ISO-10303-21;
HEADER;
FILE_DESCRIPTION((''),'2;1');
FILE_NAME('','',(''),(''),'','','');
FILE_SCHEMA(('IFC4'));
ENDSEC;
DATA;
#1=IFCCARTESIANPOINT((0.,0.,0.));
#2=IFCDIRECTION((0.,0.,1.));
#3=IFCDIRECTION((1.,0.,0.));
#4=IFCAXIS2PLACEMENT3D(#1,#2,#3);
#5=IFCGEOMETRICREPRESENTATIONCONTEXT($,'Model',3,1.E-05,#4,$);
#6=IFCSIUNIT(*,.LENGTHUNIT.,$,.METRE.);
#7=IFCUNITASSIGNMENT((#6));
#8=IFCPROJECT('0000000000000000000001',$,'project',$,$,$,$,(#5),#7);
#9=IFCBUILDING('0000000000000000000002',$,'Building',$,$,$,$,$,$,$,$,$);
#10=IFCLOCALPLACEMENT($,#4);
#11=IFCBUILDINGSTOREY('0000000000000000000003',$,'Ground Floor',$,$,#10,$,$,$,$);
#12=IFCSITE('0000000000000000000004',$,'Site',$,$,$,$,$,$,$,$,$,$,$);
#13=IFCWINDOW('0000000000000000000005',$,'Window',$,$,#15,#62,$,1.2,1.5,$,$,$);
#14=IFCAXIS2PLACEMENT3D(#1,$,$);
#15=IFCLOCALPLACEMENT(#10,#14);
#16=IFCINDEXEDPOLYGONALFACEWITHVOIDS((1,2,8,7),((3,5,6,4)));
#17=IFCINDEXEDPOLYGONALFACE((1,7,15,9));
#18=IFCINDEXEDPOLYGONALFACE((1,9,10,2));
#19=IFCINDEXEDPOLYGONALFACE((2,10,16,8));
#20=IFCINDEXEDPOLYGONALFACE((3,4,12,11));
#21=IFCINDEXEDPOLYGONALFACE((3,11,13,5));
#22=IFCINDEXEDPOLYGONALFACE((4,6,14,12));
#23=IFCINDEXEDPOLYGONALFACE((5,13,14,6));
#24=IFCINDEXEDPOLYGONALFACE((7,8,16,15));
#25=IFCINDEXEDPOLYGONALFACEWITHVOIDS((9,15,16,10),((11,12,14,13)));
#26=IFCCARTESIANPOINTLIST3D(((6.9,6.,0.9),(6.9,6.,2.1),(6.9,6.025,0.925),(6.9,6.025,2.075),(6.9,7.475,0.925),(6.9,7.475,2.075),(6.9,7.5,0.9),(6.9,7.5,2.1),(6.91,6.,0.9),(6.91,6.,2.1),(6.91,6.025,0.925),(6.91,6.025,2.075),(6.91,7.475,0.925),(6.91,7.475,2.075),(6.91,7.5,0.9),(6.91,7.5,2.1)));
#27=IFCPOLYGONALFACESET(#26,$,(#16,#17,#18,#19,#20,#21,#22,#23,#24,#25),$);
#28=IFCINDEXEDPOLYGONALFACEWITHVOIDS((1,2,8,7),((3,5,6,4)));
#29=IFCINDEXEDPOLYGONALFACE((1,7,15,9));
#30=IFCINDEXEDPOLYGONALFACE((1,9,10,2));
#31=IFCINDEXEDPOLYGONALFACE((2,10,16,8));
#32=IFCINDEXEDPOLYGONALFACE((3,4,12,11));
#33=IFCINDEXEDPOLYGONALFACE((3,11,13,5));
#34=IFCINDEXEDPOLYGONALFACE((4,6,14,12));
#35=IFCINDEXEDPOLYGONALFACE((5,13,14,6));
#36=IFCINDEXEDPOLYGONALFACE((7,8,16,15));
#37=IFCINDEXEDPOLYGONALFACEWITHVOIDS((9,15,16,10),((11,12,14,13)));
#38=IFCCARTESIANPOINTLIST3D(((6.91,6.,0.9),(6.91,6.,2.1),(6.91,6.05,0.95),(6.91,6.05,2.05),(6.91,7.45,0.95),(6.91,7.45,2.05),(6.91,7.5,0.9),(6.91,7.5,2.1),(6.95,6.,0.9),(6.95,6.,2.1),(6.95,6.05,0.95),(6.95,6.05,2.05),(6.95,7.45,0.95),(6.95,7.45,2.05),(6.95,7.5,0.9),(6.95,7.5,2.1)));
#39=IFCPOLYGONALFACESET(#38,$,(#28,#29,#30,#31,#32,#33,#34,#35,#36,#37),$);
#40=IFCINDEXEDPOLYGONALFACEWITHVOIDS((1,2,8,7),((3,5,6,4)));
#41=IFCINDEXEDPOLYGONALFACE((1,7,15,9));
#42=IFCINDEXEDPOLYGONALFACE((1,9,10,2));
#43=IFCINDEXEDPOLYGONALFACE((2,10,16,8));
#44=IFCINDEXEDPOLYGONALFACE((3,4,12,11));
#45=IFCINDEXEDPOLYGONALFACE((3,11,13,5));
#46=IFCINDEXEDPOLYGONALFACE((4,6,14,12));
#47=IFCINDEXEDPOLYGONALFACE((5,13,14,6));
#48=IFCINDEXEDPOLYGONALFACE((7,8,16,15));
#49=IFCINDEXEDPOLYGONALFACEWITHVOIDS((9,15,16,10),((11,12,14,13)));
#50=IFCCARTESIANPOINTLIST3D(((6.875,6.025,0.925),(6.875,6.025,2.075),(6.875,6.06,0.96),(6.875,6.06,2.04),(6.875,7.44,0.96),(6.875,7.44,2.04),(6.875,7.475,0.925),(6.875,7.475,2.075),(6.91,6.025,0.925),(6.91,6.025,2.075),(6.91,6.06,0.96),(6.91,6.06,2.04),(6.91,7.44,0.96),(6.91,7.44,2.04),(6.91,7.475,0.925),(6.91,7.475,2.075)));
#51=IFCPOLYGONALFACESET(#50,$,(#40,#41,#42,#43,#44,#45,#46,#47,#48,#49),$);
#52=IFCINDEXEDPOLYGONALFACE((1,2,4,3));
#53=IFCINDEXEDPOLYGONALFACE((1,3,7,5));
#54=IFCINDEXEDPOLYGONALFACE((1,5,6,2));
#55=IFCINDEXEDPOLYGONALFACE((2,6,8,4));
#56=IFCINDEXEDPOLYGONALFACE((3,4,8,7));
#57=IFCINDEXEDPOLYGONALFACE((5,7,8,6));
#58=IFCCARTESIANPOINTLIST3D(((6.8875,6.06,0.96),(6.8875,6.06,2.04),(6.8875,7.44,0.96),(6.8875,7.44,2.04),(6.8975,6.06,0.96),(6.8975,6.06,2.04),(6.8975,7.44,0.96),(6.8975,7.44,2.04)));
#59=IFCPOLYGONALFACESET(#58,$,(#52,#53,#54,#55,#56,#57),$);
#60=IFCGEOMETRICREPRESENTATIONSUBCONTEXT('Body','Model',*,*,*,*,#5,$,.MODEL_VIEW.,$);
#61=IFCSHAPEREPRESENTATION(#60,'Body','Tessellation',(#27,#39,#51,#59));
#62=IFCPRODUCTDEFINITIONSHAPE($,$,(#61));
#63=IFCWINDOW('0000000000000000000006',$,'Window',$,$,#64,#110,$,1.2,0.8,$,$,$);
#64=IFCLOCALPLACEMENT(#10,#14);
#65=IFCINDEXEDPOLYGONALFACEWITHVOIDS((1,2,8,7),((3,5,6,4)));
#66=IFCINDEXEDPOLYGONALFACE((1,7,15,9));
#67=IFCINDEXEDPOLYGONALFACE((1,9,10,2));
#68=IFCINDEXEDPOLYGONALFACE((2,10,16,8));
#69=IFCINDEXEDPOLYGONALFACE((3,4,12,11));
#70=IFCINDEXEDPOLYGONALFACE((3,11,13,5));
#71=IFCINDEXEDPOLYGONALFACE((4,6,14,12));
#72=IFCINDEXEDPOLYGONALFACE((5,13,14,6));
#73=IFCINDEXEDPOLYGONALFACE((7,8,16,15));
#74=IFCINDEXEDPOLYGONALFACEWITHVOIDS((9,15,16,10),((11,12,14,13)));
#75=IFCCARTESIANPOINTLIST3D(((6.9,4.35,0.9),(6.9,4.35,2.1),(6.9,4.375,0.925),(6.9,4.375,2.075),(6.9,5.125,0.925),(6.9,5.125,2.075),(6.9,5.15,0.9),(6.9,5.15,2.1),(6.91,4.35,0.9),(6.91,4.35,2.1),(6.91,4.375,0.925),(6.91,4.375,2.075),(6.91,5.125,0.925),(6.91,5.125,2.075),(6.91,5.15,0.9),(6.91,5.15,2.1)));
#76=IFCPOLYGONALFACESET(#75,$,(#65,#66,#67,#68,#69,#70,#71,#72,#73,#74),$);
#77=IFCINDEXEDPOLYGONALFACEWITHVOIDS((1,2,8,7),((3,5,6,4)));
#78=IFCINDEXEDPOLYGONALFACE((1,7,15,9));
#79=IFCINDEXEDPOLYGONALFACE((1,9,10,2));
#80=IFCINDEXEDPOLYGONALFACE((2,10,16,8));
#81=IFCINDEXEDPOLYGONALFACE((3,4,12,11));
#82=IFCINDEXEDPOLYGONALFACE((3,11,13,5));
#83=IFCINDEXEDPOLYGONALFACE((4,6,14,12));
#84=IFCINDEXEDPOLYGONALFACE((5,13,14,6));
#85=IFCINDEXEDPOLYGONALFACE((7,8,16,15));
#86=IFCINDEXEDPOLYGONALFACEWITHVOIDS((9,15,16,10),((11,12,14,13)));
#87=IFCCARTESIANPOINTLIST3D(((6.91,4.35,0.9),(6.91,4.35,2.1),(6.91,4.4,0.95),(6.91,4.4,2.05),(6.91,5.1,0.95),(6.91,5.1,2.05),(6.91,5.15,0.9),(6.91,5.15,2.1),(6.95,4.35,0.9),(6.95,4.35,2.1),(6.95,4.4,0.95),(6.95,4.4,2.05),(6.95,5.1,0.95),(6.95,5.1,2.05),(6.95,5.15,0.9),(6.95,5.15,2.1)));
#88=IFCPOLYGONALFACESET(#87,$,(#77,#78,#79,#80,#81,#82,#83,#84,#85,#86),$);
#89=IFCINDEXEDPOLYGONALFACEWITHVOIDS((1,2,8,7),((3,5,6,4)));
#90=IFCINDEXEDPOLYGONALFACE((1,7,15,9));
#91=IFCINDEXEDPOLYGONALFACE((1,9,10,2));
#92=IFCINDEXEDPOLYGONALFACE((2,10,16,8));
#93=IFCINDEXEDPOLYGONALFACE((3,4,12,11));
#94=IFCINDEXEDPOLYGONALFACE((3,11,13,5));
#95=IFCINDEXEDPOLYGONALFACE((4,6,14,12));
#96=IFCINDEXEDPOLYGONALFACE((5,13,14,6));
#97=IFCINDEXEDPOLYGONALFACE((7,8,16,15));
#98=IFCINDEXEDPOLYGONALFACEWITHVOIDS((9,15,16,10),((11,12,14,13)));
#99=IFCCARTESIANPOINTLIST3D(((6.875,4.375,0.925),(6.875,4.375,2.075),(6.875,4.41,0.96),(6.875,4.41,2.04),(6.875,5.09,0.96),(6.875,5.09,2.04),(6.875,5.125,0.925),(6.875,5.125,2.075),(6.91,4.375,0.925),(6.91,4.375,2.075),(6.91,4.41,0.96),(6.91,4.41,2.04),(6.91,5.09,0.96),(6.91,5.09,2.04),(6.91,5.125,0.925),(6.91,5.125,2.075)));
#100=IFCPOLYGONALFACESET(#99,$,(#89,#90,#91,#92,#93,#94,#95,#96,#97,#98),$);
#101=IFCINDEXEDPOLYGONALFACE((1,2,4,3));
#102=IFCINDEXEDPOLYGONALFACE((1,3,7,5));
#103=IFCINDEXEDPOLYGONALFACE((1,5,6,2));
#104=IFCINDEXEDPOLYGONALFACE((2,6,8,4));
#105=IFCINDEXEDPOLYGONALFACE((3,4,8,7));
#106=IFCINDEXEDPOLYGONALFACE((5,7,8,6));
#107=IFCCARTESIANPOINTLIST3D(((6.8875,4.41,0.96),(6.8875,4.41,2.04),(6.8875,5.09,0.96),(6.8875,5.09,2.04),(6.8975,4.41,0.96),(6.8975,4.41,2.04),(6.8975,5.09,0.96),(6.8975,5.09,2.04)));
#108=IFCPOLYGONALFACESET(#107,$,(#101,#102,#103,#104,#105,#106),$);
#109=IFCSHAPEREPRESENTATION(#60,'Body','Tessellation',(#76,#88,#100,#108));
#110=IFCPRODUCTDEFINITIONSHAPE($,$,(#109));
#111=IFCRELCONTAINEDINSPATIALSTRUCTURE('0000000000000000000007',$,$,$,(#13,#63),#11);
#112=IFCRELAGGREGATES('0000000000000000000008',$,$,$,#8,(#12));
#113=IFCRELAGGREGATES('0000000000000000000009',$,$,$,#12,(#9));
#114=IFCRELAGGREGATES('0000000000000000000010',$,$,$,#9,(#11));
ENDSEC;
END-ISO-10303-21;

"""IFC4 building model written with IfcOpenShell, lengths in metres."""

from ifc_helpers import new_model, si_unit, frame, origin_with_axes, place, context, subcontext, project, spatial, line, indexed_curve, outline, extrude, element, save


model = new_model("IFC4")

# Units and contexts
model_context = context("Model", 3, precision=1e-05, world=origin_with_axes())
body_context = subcontext(model_context, "Body", "Model", "MODEL_VIEW")
ifc_project = project(units=[si_unit("LENGTHUNIT", "METRE")], contexts=[model_context])

# Site, building, storey
site = spatial("IfcSite", under=ifc_project, Name="Site")
building = spatial("IfcBuilding", under=site, Name="Building")
storey_placement = place(None, origin_with_axes())
storey = spatial("IfcBuildingStorey", under=building, at=storey_placement, Name="Ground Floor")

# Windows
window_1_placement = place(storey_placement, frame((7.0, 6.0, 0.9), z_axis=(0.0, 0.0, 1.0), x_axis=(0.0, 1.0, 0.0)))
element("IfcWindow", 1, at=window_1_placement, inside=storey, Name="Window", OverallHeight=1.2, OverallWidth=1.5, context=body_context, shape_type="SweptSolid", body=[
    extrude(outline(indexed_curve([(0.0, 0.0), (1.5, 0.0), (1.5, 1.2), (0.0, 1.2)], segments=[line(1, 2, 3, 4, 1)]), holes=[indexed_curve([(0.025, 0.025), (1.475, 0.025), (1.475, 1.175), (0.025, 1.175)], segments=[line(1, 2, 3, 4, 1)])]), frame((0.0, 0.09, 0.0), z_axis=(0.0, -1.0, 0.0), x_axis=(1.0, 0.0, 0.0)), (0.0, 0.0, -1.0), 0.01),
    extrude(outline(indexed_curve([(0.0, 0.0), (1.5, 0.0), (1.5, 1.2), (0.0, 1.2)], segments=[line(1, 2, 3, 4, 1)]), holes=[indexed_curve([(0.05, 0.05), (1.45, 0.05), (1.45, 1.15), (0.05, 1.15)], segments=[line(1, 2, 3, 4, 1)])]), frame((0.0, 0.05, 0.0), z_axis=(0.0, -1.0, 0.0), x_axis=(1.0, 0.0, 0.0)), (0.0, 0.0, -1.0), 0.04),
    extrude(outline(indexed_curve([(0.0, 0.0), (1.45, 0.0), (1.45, 1.15), (0.0, 1.15)], segments=[line(1, 2, 3, 4, 1)]), holes=[indexed_curve([(0.035, 0.035), (1.415, 0.035), (1.415, 1.115), (0.035, 1.115)], segments=[line(1, 2, 3, 4, 1)])]), frame((0.025, 0.09, 0.025), z_axis=(0.0, -1.0, 0.0), x_axis=(1.0, 0.0, 0.0)), (0.0, 0.0, -1.0), 0.035),
    extrude(outline(indexed_curve([(0.035, 0.035), (1.415, 0.035), (1.415, 1.115), (0.035, 1.115)], segments=[line(1, 2, 3, 4, 1)])), frame((0.025, 0.1025, 0.025), z_axis=(0.0, -1.0, 0.0), x_axis=(1.0, 0.0, 0.0)), (0.0, 0.0, -1.0), 0.01),
])
window_2_placement = place(storey_placement, frame((7.0, 4.35, 0.9), z_axis=(0.0, 0.0, 1.0), x_axis=(0.0, 1.0, 0.0)))
element("IfcWindow", 2, at=window_2_placement, inside=storey, Name="Window", OverallHeight=1.2, OverallWidth=0.8, context=body_context, shape_type="SweptSolid", body=[
    extrude(outline(indexed_curve([(0.0, 0.0), (0.8, 0.0), (0.8, 1.2), (0.0, 1.2)], segments=[line(1, 2, 3, 4, 1)]), holes=[indexed_curve([(0.025, 0.025), (0.775, 0.025), (0.775, 1.175), (0.025, 1.175)], segments=[line(1, 2, 3, 4, 1)])]), frame((0.0, 0.09, 0.0), z_axis=(0.0, -1.0, 0.0), x_axis=(1.0, 0.0, 0.0)), (0.0, 0.0, -1.0), 0.01),
    extrude(outline(indexed_curve([(0.0, 0.0), (0.8, 0.0), (0.8, 1.2), (0.0, 1.2)], segments=[line(1, 2, 3, 4, 1)]), holes=[indexed_curve([(0.05, 0.05), (0.75, 0.05), (0.75, 1.15), (0.05, 1.15)], segments=[line(1, 2, 3, 4, 1)])]), frame((0.0, 0.05, 0.0), z_axis=(0.0, -1.0, 0.0), x_axis=(1.0, 0.0, 0.0)), (0.0, 0.0, -1.0), 0.04),
    extrude(outline(indexed_curve([(0.0, 0.0), (0.75, 0.0), (0.75, 1.15), (0.0, 1.15)], segments=[line(1, 2, 3, 4, 1)]), holes=[indexed_curve([(0.035, 0.035), (0.715, 0.035), (0.715, 1.115), (0.035, 1.115)], segments=[line(1, 2, 3, 4, 1)])]), frame((0.025, 0.09, 0.025), z_axis=(0.0, -1.0, 0.0), x_axis=(1.0, 0.0, 0.0)), (0.0, 0.0, -1.0), 0.035),
    extrude(outline(indexed_curve([(0.035, 0.035), (0.715, 0.035), (0.715, 1.115), (0.035, 1.115)], segments=[line(1, 2, 3, 4, 1)])), frame((0.025, 0.1025, 0.025), z_axis=(0.0, -1.0, 0.0), x_axis=(1.0, 0.0, 0.0)), (0.0, 0.0, -1.0), 0.01),
])

save(model, "model.ifc")
